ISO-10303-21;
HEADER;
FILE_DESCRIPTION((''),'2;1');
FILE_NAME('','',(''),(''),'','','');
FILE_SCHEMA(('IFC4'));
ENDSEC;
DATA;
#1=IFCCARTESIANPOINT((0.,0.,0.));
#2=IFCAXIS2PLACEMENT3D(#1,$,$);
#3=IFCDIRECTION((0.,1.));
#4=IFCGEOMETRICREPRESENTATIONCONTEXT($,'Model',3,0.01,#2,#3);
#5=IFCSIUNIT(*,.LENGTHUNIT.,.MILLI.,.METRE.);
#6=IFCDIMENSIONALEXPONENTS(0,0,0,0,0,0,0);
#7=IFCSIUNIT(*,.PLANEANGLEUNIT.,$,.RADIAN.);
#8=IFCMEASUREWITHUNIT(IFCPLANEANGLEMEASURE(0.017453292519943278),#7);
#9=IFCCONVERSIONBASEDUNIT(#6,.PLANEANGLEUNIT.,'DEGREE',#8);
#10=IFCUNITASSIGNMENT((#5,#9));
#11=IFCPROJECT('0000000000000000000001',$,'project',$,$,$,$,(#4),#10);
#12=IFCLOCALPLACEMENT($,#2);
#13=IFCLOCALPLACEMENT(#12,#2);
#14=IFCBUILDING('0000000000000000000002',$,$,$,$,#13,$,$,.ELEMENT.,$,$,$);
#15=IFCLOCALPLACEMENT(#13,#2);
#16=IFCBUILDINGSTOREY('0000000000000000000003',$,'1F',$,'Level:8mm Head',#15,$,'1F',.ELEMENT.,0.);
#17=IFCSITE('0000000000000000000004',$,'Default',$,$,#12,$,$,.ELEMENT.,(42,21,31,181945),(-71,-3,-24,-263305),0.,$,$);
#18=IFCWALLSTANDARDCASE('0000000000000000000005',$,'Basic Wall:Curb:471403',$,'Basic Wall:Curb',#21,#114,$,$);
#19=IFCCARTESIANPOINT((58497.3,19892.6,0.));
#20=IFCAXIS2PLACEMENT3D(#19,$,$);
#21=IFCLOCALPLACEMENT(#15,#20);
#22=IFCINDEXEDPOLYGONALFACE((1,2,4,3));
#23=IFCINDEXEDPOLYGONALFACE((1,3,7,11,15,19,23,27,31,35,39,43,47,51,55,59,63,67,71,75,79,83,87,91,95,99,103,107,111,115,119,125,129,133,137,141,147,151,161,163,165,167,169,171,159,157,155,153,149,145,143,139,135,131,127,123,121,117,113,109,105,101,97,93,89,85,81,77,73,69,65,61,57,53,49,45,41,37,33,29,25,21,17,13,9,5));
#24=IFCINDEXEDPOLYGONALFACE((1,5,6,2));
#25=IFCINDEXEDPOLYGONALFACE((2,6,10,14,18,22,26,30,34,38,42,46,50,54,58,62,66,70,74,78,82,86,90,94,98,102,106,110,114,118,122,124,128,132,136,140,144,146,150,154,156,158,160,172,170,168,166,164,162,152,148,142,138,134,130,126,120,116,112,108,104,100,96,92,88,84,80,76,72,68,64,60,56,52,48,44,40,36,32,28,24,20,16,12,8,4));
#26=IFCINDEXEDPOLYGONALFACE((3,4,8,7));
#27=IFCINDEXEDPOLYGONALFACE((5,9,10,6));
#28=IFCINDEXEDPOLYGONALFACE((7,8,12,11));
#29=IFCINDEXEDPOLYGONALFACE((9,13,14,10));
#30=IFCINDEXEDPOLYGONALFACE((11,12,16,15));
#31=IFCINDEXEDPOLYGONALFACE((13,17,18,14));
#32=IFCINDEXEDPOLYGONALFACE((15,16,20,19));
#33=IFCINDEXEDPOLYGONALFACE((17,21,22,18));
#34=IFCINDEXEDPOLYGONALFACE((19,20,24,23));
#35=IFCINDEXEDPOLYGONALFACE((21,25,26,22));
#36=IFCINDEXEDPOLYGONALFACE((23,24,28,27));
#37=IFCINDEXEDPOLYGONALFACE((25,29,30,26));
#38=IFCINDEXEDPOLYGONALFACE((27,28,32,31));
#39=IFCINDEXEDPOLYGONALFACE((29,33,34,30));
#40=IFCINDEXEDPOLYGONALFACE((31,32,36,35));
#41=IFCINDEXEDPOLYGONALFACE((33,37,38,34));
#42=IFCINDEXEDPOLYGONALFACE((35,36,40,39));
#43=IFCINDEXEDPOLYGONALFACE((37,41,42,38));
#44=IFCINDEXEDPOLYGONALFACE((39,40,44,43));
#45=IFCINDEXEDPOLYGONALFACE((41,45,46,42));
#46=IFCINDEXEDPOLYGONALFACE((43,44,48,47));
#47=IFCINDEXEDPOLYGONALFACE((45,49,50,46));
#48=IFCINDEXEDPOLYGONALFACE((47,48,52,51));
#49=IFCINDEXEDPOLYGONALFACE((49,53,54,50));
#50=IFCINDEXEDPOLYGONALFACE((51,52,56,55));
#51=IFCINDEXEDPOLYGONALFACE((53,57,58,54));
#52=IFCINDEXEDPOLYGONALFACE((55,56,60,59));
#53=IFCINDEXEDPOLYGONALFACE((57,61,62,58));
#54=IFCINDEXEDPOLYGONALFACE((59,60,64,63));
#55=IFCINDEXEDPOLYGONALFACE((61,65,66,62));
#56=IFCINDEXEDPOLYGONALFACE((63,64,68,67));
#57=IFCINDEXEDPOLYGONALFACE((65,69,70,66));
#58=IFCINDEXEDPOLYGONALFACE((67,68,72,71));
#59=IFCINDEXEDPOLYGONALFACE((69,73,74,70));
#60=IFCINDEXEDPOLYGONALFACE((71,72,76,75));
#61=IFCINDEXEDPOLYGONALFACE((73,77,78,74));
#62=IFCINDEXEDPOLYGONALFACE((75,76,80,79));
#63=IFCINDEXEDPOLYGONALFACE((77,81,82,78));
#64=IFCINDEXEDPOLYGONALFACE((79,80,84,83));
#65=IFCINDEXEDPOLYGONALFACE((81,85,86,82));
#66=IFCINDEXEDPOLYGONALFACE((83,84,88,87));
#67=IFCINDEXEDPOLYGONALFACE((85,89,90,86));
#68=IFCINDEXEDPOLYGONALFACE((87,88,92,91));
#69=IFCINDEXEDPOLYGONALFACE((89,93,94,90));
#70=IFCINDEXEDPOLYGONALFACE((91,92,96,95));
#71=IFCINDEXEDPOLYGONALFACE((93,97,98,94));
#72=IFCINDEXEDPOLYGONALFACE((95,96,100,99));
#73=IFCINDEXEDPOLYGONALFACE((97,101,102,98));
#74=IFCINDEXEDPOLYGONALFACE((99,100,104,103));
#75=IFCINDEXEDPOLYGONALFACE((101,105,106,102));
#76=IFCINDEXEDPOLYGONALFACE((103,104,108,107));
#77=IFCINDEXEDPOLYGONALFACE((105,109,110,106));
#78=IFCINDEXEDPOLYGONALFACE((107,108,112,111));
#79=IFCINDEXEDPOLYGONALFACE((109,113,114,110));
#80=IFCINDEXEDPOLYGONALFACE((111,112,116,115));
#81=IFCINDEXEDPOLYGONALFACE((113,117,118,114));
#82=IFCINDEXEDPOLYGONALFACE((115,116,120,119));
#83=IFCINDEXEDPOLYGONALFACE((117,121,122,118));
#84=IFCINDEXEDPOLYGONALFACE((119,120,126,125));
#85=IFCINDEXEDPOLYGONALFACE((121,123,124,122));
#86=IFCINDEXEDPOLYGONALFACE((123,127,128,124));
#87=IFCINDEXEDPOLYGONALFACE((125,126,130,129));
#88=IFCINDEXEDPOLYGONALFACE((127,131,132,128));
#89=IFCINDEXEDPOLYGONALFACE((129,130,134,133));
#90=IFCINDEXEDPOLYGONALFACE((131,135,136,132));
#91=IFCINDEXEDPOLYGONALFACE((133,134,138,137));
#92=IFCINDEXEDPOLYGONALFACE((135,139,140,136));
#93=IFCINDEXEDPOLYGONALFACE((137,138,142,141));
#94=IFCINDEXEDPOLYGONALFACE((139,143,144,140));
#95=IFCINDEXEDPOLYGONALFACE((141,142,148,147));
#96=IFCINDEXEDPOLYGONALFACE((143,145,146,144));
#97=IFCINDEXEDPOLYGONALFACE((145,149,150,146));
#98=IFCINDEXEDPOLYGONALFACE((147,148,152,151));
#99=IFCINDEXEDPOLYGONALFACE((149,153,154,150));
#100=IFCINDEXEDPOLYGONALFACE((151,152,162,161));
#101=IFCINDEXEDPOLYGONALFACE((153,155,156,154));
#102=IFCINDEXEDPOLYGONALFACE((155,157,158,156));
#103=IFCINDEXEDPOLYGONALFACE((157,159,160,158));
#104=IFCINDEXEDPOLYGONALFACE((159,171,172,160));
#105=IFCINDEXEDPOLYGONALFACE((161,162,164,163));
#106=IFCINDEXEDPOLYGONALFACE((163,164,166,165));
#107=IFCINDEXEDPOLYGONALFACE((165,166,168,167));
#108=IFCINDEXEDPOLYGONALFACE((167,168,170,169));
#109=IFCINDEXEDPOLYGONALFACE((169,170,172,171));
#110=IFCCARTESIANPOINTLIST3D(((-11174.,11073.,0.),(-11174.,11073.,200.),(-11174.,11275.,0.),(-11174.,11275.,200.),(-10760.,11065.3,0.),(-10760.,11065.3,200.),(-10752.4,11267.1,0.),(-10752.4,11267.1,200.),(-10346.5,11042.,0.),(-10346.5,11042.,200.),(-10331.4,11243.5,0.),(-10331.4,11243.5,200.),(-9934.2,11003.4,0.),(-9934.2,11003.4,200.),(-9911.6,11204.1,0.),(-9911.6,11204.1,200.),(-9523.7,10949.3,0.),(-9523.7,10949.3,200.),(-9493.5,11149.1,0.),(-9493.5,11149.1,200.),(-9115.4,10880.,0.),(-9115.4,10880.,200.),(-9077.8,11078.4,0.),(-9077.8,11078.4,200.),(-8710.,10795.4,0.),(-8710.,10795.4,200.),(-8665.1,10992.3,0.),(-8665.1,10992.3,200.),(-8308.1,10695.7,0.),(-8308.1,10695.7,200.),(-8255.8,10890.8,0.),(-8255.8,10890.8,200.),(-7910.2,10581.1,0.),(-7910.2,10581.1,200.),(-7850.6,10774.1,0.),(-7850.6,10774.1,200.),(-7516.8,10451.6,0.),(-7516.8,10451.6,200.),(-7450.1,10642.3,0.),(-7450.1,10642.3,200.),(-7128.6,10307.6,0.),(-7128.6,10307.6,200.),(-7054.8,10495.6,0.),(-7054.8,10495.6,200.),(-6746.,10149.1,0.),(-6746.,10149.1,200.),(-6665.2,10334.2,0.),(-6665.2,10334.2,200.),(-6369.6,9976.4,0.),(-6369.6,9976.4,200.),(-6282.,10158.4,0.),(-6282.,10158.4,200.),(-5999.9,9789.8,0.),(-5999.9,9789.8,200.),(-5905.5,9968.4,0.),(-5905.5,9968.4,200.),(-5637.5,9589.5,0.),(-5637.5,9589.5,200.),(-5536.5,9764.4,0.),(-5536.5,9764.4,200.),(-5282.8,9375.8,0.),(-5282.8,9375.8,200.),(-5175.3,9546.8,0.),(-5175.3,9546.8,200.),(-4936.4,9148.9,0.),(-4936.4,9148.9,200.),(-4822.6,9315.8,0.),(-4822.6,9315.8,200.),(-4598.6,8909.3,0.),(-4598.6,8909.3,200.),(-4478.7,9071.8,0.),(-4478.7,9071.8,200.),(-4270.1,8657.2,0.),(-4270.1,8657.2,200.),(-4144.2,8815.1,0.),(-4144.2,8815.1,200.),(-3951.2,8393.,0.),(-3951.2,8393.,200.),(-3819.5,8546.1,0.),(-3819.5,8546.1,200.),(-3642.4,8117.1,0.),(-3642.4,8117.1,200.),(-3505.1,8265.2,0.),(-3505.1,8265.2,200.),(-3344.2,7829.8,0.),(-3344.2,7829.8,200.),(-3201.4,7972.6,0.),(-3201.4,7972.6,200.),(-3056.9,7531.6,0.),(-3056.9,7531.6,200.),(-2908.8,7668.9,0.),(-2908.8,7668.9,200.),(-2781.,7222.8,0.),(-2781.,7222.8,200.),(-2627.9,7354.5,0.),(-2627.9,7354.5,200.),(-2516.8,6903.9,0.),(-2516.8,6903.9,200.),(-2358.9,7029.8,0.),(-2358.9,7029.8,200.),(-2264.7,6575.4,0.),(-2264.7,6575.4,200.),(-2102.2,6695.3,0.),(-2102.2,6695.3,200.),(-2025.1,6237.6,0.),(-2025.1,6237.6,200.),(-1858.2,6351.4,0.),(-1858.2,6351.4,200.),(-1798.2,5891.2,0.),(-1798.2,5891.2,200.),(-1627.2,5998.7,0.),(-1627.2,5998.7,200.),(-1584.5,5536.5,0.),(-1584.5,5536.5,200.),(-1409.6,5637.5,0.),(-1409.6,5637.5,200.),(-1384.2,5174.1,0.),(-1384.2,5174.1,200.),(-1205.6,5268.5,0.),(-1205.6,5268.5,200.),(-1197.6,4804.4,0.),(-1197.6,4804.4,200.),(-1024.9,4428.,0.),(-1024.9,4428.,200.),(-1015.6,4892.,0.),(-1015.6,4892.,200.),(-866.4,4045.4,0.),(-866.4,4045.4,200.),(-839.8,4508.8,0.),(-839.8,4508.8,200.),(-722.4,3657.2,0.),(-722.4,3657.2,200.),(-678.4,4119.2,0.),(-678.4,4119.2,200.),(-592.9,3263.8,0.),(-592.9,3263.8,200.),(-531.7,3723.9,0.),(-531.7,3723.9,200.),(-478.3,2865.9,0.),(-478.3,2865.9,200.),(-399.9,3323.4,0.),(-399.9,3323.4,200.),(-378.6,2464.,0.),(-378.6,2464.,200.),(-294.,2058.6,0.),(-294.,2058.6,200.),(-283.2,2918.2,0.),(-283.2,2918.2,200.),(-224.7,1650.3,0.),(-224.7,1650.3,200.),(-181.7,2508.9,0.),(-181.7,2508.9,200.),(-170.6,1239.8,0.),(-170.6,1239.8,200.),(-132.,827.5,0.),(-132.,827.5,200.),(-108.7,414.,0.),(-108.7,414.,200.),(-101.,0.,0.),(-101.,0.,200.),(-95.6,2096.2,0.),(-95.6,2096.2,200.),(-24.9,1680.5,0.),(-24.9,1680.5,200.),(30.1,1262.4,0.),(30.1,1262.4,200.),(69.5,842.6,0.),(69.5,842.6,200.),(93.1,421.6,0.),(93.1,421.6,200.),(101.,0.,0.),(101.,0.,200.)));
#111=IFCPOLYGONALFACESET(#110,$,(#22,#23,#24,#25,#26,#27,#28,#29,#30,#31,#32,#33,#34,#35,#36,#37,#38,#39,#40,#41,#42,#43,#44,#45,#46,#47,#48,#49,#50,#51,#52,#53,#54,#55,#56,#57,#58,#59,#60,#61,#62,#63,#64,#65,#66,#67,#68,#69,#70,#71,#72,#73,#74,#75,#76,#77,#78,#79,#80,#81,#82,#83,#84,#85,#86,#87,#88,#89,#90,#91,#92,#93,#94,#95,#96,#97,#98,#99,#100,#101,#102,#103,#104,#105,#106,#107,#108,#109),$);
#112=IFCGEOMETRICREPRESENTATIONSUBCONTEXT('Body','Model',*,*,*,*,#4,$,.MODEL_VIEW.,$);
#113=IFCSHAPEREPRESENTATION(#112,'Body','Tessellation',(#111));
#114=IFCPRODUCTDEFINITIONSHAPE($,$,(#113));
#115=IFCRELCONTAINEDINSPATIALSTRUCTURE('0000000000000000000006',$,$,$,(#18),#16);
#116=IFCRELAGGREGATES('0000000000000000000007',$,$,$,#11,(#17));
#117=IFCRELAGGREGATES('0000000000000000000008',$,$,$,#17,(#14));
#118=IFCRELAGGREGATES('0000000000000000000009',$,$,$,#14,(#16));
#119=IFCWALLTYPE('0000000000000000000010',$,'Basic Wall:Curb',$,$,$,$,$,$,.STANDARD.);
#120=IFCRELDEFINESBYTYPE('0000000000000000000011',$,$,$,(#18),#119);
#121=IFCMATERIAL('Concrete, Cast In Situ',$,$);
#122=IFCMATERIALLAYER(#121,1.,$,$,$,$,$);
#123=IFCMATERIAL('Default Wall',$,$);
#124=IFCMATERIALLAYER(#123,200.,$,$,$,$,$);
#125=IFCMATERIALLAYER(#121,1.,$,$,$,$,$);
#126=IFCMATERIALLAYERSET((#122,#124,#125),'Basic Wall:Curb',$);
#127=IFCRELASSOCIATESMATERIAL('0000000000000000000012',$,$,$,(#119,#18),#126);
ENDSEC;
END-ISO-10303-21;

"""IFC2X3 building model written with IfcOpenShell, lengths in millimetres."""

from ifc_helpers import new_model, entity, si_unit, converted_unit, direction, frame, frame_2d, origin, place, context, subcontext, project, spatial, polyline, circle_curve, parameter, trimmed, segment, composite_curve, outline, extrude, material, layer, layer_set, layer_usage, type_object, element, save


model = new_model("IFC2X3")

# Units and contexts
model_context = context("Model", 3, precision=0.01, world=origin(), true_north=direction((0.0, 1.0)))
body_context = subcontext(model_context, "Body", "Model", "MODEL_VIEW")
ifc_project = project(units=[si_unit("LENGTHUNIT", "METRE", prefix="MILLI"), converted_unit("PLANEANGLEUNIT", "DEGREE", entity("IfcPlaneAngleMeasure", 0.017453292519943278), si_unit("PLANEANGLEUNIT", "RADIAN"), dimensions=[0, 0, 0, 0, 0, 0, 0])], contexts=[model_context])

# Site, building, storey
site_placement = place(None, origin())
site = spatial("IfcSite", under=ifc_project, at=site_placement, Name="Default", CompositionType="ELEMENT", RefLatitude=(42, 21, 31, 181945), RefLongitude=(-71, -3, -24, -263305), RefElevation=0.0)
building_placement = place(site_placement, origin())
building = spatial("IfcBuilding", under=site, at=building_placement, CompositionType="ELEMENT")
storey_placement = place(building_placement, origin())
storey = spatial("IfcBuildingStorey", under=building, at=storey_placement, Name="1F", ObjectType="Level:8mm Head", LongName="1F", CompositionType="ELEMENT", Elevation=0.0)

# Shared definitions
ifc_material_1 = material(Name="Default Wall")

# Wall
ifc_material_2 = material(Name="Concrete, Cast In Situ")
ifc_layer_1 = layer(ifc_material_2, 1.0)
ifc_layer_2 = layer(ifc_material_1, 200.0)
ifc_layer_3 = layer(ifc_material_2, 1.0)
ifc_layer_set_1 = layer_set([ifc_layer_1, ifc_layer_2, ifc_layer_3], Name="Basic Wall:Curb")
wall_type_1 = type_object("IfcWallType", Name="Basic Wall:Curb", PredefinedType="STANDARD", material=ifc_layer_set_1)
ifc_layer_usage_1 = layer_usage(ifc_layer_set_1, "AXIS2", "NEGATIVE", 101.0)
wall_1_placement = place(storey_placement, frame((58497.3, 19892.6, 0.0)))
element("IfcWallStandardCase", 1, at=wall_1_placement, inside=storey, type_object=wall_type_1, material=ifc_layer_usage_1, Name="Basic Wall:Curb:471403", ObjectType="Basic Wall:Curb", context=body_context, shape_type="SweptSolid", body=[
    extrude(outline(composite_curve([segment(trimmed(circle_curve(frame_2d((-11174.0, 0.0), x_axis=(1.0, 0.0)), 11073.0), [parameter(360.0)], [parameter(90.0)], True, "PARAMETER"), False, "CONTINUOUS"), segment(polyline([(-101.0, 0.0), (101.0, 0.0)]), True, "CONTINUOUS"), segment(trimmed(circle_curve(frame_2d((-11174.0, 0.0), x_axis=(1.0, 0.0)), 11275.0), [parameter(360.0)], [parameter(90.0)], True, "PARAMETER"), True, "CONTINUOUS"), segment(polyline([(-11174.0, 11275.0), (-11174.0, 11073.0)]), True, "CONTINUOUS")], self_intersect=False)), origin(), (0.0, 0.0, 1.0), 200.0),
])

save(model, "model.ifc")
